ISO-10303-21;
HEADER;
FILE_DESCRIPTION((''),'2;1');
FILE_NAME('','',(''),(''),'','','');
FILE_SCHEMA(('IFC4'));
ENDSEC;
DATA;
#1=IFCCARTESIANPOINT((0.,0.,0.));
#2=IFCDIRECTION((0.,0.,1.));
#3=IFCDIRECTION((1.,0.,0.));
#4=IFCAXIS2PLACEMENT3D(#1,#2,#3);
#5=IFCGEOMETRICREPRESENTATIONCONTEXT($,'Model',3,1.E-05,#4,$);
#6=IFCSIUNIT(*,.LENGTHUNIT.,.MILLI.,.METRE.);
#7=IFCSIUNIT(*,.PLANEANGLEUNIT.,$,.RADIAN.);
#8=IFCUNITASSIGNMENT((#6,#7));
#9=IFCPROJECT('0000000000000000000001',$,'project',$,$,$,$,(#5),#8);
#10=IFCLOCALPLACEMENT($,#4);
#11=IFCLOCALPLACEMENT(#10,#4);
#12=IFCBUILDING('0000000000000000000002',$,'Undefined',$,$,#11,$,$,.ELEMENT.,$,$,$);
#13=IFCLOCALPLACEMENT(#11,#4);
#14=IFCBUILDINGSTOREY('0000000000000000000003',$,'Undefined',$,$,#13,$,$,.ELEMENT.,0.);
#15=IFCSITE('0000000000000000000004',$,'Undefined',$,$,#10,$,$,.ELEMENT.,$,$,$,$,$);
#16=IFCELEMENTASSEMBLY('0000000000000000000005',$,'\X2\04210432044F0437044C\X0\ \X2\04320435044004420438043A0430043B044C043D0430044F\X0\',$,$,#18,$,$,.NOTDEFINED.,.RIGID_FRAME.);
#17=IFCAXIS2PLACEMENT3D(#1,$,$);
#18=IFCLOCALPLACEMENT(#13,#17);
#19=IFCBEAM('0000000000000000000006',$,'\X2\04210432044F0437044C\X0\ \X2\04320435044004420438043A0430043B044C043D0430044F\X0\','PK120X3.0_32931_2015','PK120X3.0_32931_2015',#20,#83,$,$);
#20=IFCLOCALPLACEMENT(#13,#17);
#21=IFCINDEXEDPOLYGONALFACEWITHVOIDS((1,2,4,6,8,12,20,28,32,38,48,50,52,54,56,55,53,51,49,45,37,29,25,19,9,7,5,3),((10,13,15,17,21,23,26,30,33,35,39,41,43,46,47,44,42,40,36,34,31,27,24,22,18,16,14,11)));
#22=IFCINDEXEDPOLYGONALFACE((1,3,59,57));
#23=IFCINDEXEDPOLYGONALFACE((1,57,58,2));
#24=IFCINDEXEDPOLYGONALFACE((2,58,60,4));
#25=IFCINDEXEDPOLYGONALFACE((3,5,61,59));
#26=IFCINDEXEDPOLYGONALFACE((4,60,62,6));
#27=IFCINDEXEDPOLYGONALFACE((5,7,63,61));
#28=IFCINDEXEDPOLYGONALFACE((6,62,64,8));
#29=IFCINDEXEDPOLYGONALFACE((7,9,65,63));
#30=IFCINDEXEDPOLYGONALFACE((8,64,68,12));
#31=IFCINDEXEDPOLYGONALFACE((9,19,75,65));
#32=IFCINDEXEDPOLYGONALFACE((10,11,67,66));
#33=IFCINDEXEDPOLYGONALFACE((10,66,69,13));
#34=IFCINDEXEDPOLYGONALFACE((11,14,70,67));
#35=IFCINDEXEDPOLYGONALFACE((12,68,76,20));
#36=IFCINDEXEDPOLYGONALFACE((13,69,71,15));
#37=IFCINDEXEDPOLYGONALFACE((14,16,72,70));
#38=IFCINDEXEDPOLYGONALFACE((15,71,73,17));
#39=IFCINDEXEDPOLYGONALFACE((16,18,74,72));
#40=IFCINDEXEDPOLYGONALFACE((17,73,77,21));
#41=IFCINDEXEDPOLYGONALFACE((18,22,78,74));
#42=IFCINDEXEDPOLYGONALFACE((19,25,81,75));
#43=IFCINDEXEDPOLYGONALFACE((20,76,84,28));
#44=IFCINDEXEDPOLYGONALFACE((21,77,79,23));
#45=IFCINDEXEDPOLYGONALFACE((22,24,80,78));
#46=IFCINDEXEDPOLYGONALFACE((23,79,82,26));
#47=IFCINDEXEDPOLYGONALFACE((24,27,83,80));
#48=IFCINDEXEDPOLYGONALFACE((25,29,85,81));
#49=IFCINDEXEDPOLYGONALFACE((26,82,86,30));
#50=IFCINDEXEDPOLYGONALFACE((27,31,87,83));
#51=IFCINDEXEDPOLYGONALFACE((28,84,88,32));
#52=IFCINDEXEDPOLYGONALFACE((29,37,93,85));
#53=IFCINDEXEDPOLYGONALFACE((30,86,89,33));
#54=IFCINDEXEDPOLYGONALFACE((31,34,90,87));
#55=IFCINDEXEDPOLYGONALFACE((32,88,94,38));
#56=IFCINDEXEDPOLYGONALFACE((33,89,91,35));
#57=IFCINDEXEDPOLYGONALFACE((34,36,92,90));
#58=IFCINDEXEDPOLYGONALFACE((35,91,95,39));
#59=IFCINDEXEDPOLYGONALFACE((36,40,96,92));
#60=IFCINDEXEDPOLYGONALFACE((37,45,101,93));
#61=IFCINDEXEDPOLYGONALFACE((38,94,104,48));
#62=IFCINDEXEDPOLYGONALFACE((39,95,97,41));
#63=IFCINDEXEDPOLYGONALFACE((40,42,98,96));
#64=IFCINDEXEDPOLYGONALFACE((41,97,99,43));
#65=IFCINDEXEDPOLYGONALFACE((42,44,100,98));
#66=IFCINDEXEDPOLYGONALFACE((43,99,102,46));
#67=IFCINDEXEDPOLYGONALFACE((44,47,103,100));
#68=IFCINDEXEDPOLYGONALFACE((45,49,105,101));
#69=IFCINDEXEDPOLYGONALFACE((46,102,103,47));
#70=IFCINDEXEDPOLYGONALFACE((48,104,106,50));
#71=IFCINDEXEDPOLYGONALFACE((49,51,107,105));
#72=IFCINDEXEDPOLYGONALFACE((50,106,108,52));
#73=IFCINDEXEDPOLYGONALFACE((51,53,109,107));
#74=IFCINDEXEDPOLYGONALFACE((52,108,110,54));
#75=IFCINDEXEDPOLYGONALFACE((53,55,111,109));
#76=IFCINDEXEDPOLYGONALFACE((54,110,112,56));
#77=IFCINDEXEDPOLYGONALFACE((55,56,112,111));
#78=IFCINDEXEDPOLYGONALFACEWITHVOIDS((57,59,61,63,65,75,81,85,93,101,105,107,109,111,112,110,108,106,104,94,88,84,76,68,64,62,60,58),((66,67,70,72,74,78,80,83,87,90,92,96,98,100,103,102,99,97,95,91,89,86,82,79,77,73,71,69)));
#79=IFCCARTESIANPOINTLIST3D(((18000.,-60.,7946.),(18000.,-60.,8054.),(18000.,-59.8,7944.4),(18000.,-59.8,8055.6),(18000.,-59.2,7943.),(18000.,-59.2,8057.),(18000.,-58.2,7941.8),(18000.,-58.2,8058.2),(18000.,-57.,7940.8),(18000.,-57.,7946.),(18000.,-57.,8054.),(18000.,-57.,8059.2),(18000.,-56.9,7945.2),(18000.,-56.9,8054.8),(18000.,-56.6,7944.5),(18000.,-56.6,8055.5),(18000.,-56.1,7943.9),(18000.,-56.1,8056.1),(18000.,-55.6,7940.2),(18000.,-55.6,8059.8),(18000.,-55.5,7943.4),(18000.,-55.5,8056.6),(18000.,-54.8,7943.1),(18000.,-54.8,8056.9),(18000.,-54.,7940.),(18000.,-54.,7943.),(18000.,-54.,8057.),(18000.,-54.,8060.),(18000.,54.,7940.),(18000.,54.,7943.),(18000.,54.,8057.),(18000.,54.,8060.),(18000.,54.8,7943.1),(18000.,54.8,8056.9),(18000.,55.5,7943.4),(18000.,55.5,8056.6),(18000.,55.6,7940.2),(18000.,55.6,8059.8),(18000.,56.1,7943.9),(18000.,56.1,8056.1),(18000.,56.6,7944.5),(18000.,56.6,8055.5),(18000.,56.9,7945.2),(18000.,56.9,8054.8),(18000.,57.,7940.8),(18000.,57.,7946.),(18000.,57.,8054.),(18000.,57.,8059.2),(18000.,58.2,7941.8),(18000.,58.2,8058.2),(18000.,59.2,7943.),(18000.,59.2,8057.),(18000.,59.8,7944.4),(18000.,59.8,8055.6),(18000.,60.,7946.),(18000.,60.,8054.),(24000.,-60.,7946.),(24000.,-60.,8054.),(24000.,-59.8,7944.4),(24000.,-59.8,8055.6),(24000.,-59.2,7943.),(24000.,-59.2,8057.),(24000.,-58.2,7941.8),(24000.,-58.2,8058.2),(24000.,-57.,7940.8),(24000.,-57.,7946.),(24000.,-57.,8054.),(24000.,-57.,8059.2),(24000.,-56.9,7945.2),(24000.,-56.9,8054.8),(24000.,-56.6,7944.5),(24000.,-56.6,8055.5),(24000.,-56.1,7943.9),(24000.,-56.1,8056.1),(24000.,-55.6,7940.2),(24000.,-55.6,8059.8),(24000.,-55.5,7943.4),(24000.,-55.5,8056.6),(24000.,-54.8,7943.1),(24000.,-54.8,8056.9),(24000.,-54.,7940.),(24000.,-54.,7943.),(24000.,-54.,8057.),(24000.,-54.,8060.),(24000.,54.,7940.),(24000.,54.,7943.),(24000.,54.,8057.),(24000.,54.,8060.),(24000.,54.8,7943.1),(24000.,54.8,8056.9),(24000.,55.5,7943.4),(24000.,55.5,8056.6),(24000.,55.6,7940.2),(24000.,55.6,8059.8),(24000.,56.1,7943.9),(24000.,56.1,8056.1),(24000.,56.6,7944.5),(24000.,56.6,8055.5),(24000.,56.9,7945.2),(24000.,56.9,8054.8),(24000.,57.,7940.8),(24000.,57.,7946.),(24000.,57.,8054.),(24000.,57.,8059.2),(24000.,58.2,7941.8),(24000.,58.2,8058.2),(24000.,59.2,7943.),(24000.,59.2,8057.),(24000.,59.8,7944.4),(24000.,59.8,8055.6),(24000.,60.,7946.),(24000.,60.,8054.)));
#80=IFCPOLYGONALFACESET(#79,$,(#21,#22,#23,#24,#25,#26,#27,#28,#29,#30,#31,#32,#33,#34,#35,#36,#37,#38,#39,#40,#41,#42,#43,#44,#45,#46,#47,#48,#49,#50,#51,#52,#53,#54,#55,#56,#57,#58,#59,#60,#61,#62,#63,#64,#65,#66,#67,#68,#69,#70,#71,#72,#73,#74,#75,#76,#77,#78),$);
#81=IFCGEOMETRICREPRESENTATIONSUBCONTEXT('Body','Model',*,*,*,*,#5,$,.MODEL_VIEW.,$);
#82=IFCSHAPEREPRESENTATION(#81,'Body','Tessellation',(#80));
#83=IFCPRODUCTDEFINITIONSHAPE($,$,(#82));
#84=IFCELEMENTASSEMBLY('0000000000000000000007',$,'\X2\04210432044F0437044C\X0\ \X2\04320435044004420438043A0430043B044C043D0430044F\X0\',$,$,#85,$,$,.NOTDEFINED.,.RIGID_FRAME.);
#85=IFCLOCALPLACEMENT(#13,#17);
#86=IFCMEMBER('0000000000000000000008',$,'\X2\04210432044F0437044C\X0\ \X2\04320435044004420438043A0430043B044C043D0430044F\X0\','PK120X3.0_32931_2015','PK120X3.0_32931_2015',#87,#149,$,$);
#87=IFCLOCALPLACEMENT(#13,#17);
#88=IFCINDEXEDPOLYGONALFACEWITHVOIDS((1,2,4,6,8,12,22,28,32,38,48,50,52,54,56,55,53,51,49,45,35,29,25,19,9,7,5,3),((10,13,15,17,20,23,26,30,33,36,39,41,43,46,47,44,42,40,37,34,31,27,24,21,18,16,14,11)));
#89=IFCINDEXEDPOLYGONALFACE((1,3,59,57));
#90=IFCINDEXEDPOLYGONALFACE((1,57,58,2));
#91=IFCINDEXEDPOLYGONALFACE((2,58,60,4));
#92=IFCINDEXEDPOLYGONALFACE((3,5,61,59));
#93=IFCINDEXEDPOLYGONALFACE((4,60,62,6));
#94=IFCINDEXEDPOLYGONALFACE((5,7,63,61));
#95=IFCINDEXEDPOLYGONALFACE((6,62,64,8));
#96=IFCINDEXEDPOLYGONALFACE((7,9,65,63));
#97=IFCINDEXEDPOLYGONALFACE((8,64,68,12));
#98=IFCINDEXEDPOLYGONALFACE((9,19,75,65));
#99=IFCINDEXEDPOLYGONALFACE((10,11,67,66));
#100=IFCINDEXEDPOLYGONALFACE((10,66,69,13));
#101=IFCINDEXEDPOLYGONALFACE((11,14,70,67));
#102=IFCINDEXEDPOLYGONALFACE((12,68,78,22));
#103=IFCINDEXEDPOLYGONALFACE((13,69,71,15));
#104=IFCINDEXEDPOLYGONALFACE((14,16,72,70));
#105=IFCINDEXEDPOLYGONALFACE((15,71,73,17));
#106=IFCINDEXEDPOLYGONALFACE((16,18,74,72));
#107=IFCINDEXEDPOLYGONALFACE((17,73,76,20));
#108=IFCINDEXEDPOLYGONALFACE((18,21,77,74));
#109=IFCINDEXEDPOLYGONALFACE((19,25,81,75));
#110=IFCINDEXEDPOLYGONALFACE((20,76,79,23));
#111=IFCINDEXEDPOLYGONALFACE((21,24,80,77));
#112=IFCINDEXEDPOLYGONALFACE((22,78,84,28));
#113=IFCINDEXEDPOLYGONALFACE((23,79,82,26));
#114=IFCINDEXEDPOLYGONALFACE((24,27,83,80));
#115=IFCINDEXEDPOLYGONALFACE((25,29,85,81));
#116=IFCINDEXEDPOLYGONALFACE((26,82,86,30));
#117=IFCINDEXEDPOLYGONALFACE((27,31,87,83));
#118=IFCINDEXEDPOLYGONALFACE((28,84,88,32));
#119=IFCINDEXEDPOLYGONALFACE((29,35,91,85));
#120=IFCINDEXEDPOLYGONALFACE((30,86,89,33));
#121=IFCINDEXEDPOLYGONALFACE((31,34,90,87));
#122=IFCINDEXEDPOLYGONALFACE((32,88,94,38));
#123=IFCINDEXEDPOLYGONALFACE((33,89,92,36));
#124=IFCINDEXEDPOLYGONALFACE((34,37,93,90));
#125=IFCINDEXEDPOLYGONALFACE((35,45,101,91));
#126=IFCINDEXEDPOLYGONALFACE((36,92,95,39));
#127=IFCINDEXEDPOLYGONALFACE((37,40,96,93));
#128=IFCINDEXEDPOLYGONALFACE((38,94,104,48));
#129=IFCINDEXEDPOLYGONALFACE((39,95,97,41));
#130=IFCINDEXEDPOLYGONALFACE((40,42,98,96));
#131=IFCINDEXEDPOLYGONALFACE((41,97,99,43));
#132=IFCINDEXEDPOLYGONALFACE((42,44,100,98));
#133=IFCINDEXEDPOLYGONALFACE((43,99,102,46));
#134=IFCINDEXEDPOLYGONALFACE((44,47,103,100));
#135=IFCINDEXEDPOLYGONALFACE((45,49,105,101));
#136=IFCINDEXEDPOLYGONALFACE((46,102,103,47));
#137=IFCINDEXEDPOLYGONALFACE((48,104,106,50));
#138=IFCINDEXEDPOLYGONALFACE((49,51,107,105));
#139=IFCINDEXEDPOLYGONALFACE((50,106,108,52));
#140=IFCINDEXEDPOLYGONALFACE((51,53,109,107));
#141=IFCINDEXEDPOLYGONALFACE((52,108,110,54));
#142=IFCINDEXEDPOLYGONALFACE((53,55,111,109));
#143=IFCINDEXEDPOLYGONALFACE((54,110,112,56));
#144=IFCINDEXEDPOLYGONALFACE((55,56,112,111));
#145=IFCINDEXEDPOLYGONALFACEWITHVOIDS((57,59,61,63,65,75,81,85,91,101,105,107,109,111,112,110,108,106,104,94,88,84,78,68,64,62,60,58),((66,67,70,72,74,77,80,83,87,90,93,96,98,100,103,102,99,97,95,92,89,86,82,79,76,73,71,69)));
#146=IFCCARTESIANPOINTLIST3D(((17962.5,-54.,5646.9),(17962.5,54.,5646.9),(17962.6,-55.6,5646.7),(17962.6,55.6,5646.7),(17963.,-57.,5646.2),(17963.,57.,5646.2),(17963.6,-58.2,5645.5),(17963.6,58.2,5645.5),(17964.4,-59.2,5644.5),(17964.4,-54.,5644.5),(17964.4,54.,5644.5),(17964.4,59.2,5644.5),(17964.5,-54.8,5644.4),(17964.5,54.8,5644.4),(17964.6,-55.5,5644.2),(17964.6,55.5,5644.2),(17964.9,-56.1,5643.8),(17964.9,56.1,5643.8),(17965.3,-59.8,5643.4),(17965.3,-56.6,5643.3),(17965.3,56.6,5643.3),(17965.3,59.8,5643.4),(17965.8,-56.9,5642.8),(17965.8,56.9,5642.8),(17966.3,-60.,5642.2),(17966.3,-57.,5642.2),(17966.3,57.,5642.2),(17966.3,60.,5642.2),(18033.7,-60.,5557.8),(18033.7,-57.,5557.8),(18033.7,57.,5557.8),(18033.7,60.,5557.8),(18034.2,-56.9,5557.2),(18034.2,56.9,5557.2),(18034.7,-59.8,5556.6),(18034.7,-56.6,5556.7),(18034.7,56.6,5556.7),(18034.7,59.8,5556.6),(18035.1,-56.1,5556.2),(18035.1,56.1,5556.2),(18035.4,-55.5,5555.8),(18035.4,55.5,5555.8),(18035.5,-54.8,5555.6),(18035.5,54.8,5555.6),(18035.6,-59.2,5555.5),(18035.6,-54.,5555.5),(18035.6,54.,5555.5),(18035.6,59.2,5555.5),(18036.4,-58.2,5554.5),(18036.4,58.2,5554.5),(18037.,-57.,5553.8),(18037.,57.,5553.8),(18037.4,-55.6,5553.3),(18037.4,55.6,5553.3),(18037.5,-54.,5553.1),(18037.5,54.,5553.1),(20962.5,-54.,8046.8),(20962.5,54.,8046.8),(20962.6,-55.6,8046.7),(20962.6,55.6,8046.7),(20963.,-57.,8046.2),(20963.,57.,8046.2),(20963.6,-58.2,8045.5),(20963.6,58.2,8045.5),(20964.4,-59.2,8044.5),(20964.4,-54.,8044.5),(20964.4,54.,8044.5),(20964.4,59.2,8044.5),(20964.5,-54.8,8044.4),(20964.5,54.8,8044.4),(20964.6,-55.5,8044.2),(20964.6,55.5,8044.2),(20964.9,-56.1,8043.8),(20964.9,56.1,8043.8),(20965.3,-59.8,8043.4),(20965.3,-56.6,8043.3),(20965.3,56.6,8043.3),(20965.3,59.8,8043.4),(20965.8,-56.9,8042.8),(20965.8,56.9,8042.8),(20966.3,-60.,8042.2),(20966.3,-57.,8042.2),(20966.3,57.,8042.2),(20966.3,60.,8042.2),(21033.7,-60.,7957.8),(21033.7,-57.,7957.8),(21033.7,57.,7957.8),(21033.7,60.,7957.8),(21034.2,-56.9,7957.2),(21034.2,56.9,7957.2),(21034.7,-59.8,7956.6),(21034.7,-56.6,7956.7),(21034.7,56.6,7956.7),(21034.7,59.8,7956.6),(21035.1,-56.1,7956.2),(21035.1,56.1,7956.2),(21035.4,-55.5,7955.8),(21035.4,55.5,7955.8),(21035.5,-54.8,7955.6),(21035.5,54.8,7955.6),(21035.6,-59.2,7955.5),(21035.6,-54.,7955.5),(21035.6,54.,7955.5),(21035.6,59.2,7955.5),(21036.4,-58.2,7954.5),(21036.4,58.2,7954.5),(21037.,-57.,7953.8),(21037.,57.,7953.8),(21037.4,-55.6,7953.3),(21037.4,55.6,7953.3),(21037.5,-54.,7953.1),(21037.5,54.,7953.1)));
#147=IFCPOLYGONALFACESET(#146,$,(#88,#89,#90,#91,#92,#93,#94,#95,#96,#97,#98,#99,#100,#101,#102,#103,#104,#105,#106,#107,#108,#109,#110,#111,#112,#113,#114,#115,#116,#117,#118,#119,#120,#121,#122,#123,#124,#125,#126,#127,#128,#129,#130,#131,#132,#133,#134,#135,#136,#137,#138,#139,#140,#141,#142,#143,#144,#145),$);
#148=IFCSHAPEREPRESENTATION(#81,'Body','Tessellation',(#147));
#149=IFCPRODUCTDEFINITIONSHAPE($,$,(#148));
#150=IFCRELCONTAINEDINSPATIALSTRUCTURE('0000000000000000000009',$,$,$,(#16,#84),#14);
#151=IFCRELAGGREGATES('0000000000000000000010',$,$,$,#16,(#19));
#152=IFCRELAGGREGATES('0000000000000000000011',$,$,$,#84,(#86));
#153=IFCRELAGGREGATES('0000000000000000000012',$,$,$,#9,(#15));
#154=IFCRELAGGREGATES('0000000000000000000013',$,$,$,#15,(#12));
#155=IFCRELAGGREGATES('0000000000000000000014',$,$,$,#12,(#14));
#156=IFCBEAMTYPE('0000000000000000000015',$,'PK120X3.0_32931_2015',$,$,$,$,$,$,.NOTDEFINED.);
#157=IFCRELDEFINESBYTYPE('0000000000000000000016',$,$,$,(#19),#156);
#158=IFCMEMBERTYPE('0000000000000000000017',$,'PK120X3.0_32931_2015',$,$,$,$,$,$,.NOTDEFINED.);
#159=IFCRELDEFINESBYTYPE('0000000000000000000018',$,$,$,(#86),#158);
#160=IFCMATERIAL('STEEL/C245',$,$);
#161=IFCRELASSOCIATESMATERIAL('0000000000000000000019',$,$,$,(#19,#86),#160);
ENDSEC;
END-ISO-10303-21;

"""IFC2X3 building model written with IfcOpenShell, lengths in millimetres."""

from ifc_helpers import new_model, si_unit, frame, origin_with_axes, origin_2d_with_axis, place, context, subcontext, project, spatial, hollow_rectangle, extrude, material, type_object, element, aggregate, save


model = new_model("IFC2X3")

# Units and contexts
model_context = context("Model", 3, precision=1e-05, world=origin_with_axes())
body_context = subcontext(model_context, "Body", "Model", "MODEL_VIEW")
ifc_project = project(units=[si_unit("LENGTHUNIT", "METRE", prefix="MILLI"), si_unit("PLANEANGLEUNIT", "RADIAN")], contexts=[model_context])

# Site, building, storey
site_placement = place(None, origin_with_axes())
site = spatial("IfcSite", under=ifc_project, at=site_placement, Name="Undefined", CompositionType="ELEMENT")
building_placement = place(site_placement, origin_with_axes())
building = spatial("IfcBuilding", under=site, at=building_placement, Name="Undefined", CompositionType="ELEMENT")
storey_placement = place(building_placement, origin_with_axes())
storey = spatial("IfcBuildingStorey", under=building, at=storey_placement, Name="Undefined", CompositionType="ELEMENT", Elevation=0.0)

# Shared definitions
ifc_material_1 = material(Name="STEEL/C245")

# Element assembly, beam
beam_type_1 = type_object("IfcBeamType", Name="PK120X3.0_32931_2015", PredefinedType="NOTDEFINED")
assembly_1_placement = place(storey_placement, origin_with_axes())
assembly_1 = element("IfcElementAssembly", 1, at=assembly_1_placement, inside=storey, Name="Связь вертикальная", AssemblyPlace="NOTDEFINED", PredefinedType="RIGID_FRAME")
beam_1_placement = place(assembly_1_placement, frame((18000.0, 0.0, 8000.0), z_axis=(0.0, 0.0, 1.0), x_axis=(1.0, 0.0, 0.0)))
beam_1 = element("IfcBeam", 2, at=beam_1_placement, type_object=beam_type_1, material=ifc_material_1, Name="Связь вертикальная", Description="PK120X3.0_32931_2015", ObjectType="PK120X3.0_32931_2015", context=body_context, shape_type="SweptSolid", body=[
    extrude(hollow_rectangle(XDim=120.0, YDim=120.0, WallThickness=3.0, InnerFilletRadius=3.0, OuterFilletRadius=6.0, at=origin_2d_with_axis()), frame((6000.0, 0.0, 0.0), z_axis=(-1.0, 0.0, 0.0), x_axis=(0.0, -1.0, 0.0)), (0.0, 0.0, 1.0), 6000.0),
])
aggregate(assembly_1, [beam_1])

# Element assembly, member
assembly_2_placement = place(storey_placement, origin_with_axes())
assembly_2 = element("IfcElementAssembly", 3, at=assembly_2_placement, inside=storey, Name="Связь вертикальная", AssemblyPlace="NOTDEFINED", PredefinedType="RIGID_FRAME")
member_type_1 = type_object("IfcMemberType", Name="PK120X3.0_32931_2015", PredefinedType="NOTDEFINED")
member_1_placement = place(assembly_2_placement, frame((21000.0, 0.0, 8000.0), z_axis=(0.624695, 0.0, -0.780869), x_axis=(-0.780869, 0.0, -0.624695)))
member_1 = element("IfcMember", 4, at=member_1_placement, type_object=member_type_1, material=ifc_material_1, Name="Связь вертикальная", Description="PK120X3.0_32931_2015", ObjectType="PK120X3.0_32931_2015", context=body_context, shape_type="SweptSolid", body=[
    extrude(hollow_rectangle(XDim=120.0, YDim=120.0, WallThickness=3.0, InnerFilletRadius=3.0, OuterFilletRadius=6.0, at=origin_2d_with_axis()), frame((3841.9, 0.0, 0.0), z_axis=(-1.0, 0.0, 0.0), x_axis=(0.0, -1.0, 0.0)), (0.0, 0.0, 1.0), 3841.9),
])
aggregate(assembly_2, [member_1])

save(model, "model.ifc")
